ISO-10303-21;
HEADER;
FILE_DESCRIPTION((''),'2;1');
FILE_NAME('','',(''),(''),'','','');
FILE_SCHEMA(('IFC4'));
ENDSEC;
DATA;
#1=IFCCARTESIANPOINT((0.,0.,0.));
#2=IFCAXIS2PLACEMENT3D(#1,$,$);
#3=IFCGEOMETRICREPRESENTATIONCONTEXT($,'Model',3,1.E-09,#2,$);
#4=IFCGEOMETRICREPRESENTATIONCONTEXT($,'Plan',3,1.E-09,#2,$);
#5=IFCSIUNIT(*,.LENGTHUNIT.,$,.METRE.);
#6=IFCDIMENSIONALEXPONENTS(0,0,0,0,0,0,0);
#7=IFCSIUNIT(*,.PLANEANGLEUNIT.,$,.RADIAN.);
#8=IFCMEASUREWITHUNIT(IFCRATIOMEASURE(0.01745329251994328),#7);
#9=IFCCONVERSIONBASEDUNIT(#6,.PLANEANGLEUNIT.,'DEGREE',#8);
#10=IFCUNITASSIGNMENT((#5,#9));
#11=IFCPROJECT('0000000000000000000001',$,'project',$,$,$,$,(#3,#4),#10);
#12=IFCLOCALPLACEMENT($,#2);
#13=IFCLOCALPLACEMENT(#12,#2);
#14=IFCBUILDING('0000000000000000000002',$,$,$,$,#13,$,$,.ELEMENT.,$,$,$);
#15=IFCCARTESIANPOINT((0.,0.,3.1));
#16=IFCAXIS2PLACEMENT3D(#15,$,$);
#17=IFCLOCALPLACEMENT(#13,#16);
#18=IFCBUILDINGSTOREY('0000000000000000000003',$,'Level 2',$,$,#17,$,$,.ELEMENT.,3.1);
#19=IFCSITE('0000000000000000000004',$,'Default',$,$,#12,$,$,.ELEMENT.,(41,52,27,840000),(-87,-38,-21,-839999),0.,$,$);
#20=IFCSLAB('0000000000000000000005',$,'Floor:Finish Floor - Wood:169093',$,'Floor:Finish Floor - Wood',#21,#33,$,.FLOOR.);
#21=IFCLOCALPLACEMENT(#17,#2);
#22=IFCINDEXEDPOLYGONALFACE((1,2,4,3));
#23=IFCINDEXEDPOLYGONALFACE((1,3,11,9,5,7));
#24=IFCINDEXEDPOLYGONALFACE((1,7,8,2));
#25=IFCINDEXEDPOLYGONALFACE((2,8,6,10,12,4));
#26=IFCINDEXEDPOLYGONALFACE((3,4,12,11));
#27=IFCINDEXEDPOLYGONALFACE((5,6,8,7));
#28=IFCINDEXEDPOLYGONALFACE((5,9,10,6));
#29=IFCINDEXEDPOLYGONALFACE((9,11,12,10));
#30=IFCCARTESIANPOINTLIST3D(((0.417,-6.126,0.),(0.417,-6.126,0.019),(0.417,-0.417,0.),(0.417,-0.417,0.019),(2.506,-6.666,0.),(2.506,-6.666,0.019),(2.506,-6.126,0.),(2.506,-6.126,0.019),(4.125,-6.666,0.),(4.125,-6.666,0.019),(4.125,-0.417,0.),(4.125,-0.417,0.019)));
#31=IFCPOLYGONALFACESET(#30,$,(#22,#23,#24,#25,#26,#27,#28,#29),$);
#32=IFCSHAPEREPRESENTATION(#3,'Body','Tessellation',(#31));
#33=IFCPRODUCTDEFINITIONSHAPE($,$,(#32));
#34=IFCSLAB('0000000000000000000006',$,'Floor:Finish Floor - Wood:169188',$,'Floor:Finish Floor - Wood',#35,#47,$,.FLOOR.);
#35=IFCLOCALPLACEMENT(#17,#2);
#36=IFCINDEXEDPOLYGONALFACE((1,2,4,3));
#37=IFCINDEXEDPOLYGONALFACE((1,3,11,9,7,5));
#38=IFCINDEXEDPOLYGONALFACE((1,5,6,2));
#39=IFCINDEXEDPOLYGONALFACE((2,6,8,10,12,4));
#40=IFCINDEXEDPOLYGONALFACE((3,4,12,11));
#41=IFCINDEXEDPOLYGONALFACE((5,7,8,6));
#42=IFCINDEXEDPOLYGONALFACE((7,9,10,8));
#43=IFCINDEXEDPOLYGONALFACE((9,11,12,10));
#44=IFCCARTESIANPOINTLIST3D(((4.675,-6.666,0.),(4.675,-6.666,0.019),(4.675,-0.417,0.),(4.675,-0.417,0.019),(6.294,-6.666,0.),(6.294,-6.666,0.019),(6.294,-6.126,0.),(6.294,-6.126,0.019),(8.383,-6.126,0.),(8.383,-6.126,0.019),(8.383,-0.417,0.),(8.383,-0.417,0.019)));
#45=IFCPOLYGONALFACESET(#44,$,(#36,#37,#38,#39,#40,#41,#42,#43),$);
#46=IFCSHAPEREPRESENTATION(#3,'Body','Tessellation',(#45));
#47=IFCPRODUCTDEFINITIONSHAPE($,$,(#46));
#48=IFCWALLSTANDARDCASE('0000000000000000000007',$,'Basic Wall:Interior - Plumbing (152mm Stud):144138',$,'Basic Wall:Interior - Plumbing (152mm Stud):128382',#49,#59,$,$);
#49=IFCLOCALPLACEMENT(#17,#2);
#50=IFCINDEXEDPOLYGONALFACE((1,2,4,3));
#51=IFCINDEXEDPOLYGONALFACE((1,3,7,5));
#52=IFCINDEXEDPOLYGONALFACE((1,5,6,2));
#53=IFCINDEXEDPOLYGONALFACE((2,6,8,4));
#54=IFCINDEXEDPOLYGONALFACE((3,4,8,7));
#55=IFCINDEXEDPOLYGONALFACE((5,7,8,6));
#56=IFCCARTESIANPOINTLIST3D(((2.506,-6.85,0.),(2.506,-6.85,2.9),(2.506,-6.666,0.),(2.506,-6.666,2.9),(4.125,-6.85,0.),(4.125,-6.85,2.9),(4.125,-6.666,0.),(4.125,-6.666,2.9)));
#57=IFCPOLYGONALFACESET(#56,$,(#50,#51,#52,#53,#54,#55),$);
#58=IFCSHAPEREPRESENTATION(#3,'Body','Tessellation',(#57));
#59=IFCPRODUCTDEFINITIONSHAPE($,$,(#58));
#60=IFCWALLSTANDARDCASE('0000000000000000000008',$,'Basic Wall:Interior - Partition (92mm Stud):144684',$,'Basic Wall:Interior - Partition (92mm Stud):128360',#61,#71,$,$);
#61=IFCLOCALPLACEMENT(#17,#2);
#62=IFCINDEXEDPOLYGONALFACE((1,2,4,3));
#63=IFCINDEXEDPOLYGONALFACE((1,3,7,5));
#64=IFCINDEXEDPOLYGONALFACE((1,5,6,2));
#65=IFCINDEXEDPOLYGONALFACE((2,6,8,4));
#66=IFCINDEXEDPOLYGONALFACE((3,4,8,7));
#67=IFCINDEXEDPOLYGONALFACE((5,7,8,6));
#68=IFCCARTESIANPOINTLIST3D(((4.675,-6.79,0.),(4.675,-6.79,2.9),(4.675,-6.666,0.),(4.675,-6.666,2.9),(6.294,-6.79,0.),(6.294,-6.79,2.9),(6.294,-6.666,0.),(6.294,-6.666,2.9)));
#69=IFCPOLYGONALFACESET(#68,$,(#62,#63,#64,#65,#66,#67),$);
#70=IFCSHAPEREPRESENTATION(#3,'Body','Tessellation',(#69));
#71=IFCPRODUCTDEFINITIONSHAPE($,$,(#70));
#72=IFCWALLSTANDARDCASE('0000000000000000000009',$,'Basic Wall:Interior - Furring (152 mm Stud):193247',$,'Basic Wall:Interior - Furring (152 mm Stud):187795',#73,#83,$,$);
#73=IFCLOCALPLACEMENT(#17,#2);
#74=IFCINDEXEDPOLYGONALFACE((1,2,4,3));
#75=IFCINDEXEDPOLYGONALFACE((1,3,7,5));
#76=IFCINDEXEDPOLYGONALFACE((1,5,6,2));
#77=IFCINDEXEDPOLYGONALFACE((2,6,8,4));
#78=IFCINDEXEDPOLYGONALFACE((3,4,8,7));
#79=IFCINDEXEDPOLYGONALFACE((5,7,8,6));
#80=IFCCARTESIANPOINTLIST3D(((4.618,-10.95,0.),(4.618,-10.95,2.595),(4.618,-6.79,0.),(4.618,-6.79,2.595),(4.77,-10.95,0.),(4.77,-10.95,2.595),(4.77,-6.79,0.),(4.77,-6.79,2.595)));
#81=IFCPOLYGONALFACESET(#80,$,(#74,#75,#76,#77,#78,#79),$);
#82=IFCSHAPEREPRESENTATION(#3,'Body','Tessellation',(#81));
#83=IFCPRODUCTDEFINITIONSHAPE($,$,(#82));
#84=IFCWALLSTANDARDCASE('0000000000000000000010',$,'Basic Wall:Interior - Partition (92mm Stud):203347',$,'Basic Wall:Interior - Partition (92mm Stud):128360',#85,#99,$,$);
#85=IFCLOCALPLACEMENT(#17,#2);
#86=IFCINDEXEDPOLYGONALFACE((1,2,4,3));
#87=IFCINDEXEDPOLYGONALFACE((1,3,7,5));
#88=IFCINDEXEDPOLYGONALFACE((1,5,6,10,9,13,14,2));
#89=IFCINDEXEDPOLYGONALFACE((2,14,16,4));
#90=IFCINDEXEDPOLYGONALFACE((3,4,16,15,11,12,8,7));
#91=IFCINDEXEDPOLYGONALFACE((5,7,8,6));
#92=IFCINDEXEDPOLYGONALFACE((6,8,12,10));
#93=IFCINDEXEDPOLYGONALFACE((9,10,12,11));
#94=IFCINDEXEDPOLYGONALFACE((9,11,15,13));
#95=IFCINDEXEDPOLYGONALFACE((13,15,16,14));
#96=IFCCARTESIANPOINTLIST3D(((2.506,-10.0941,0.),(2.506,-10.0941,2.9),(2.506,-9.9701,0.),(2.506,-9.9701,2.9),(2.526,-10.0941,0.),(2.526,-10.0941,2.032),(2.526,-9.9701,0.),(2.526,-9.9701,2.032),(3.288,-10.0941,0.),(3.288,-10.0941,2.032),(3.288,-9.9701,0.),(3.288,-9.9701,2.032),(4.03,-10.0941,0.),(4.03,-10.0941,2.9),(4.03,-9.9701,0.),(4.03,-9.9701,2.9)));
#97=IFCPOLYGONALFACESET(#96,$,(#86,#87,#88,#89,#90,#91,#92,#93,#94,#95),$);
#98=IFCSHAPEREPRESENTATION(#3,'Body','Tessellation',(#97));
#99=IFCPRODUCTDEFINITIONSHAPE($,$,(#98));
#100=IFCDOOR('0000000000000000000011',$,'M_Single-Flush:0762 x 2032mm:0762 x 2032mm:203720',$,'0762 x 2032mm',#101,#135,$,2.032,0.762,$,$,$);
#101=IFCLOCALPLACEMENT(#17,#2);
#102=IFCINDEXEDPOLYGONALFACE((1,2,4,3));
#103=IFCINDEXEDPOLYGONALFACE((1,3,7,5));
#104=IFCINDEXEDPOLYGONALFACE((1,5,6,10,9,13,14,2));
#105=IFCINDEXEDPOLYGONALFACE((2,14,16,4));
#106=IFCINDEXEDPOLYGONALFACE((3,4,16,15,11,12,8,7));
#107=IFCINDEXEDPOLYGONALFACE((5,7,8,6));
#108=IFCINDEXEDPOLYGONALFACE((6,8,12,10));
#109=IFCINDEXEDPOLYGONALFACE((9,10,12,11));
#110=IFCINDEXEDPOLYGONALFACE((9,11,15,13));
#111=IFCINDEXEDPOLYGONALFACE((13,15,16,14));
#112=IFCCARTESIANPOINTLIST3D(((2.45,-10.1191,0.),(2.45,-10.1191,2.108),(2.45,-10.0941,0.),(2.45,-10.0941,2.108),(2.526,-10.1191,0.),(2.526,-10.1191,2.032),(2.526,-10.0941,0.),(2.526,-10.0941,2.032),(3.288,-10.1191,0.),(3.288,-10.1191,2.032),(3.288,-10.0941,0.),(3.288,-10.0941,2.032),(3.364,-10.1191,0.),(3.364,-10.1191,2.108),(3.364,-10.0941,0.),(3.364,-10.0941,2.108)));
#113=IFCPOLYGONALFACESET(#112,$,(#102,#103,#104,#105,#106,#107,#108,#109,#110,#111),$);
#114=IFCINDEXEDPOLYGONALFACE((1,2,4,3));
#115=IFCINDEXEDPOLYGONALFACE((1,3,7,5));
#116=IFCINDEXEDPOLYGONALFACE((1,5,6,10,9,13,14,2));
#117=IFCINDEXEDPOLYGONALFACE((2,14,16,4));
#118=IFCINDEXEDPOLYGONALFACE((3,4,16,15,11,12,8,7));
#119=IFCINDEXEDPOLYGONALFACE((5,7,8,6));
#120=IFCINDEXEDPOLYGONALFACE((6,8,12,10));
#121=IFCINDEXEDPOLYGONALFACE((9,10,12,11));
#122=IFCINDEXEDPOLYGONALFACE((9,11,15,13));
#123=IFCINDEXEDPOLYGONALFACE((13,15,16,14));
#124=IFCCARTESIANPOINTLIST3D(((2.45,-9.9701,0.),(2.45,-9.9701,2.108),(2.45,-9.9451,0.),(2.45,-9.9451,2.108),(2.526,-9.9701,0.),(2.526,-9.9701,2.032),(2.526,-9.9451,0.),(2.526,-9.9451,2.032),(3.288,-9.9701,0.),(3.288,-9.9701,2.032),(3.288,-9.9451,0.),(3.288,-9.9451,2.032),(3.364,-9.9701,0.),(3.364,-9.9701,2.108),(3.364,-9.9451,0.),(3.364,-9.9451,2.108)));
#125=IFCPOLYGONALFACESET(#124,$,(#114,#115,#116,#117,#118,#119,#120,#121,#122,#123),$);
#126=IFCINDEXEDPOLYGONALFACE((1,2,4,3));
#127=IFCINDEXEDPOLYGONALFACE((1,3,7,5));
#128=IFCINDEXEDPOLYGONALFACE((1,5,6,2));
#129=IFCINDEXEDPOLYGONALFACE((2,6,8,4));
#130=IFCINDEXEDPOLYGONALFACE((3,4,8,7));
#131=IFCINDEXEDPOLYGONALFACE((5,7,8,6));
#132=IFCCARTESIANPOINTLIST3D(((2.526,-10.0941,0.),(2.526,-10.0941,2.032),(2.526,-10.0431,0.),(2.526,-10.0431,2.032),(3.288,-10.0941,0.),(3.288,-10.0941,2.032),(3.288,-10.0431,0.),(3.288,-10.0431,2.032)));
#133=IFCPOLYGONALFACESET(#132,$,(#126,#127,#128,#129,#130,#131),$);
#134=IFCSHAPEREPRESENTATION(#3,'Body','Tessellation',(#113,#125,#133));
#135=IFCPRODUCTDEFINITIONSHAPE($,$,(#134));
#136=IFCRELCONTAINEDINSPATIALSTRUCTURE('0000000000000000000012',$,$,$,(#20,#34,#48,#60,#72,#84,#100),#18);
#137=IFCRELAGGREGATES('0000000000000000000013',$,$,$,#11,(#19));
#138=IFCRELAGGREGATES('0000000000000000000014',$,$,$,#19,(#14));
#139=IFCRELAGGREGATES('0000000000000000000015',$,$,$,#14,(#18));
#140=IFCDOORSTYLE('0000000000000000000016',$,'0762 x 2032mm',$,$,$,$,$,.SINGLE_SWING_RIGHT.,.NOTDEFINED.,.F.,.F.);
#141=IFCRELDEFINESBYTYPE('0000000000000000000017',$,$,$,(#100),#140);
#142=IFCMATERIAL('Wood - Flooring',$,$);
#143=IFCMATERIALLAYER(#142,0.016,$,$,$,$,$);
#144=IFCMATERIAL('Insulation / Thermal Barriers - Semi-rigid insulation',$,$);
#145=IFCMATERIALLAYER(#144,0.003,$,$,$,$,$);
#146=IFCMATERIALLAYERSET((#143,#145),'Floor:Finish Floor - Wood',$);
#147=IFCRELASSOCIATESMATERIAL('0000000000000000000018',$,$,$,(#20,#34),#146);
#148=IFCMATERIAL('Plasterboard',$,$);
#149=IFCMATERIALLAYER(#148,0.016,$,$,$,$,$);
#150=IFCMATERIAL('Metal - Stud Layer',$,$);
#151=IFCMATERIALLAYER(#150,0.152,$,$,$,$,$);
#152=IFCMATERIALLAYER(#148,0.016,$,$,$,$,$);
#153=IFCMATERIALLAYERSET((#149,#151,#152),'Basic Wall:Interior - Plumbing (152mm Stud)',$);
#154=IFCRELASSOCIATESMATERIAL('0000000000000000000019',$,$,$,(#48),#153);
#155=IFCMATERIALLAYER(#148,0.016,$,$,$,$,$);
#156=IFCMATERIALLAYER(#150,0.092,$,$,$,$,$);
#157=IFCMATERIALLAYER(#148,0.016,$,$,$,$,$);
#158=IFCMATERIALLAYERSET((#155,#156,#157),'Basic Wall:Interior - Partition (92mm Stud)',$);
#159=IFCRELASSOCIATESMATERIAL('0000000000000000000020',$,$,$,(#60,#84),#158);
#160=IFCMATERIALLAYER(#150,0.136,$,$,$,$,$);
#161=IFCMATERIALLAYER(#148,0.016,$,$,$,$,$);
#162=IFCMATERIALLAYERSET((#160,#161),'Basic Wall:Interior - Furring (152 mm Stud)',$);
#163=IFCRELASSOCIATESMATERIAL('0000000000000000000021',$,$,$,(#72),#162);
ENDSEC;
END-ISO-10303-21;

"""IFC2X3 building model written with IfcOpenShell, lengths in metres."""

from ifc_helpers import new_model, entity, si_unit, converted_unit, frame, frame_2d, origin, origin_2d_with_axis, place, context, project, spatial, polyline, rectangle, outline, extrude, source, transform, mapped, material, layer, layer_set, layer_usage, type_object, type_shapes, element, fill, save


model = new_model("IFC2X3")

# Units and contexts
model_context = context("Model", 3, precision=1e-09, world=origin())
plan_context = context("Plan", 3, precision=1e-09, world=origin())
ifc_project = project(units=[si_unit("LENGTHUNIT", "METRE"), converted_unit("PLANEANGLEUNIT", "DEGREE", entity("IfcRatioMeasure", 0.01745329251994328), si_unit("PLANEANGLEUNIT", "RADIAN"), dimensions=[0, 0, 0, 0, 0, 0, 0])], contexts=[model_context, plan_context])

# Site, building, storey
site_placement = place(None, origin())
site = spatial("IfcSite", under=ifc_project, at=site_placement, Name="Default", CompositionType="ELEMENT", RefLatitude=(41, 52, 27, 840000), RefLongitude=(-87, -38, -21, -839999), RefElevation=0.0)
building_placement = place(site_placement, origin())
building = spatial("IfcBuilding", under=site, at=building_placement, CompositionType="ELEMENT")
storey_placement = place(building_placement, frame((0.0, 0.0, 3.1)))
storey = spatial("IfcBuildingStorey", under=building, at=storey_placement, Name="Level 2", CompositionType="ELEMENT", Elevation=3.1)

# Slabs
ifc_material_1 = material(Name="Wood - Flooring")
ifc_layer_1 = layer(ifc_material_1, 0.016)
ifc_material_2 = material(Name="Insulation / Thermal Barriers - Semi-rigid insulation")
ifc_layer_2 = layer(ifc_material_2, 0.003)
ifc_layer_set_1 = layer_set([ifc_layer_1, ifc_layer_2], Name="Floor:Finish Floor - Wood")
ifc_layer_usage_1 = layer_usage(ifc_layer_set_1, "AXIS3", "POSITIVE", 0.0)
slab_1_placement = place(storey_placement, frame((0.417, -6.666, 0.0)))
element("IfcSlab", 1, at=slab_1_placement, inside=storey, material=ifc_layer_usage_1, Name="Floor:Finish Floor - Wood:169093", ObjectType="Floor:Finish Floor - Wood", PredefinedType="FLOOR", context=model_context, shape_type="SweptSolid", body=[
    extrude(outline(polyline([(1.854, 3.1245), (-1.854, 3.1245), (-1.854, -3.1245), (-0.235, -3.1245), (-0.235, -2.5845), (1.854, -2.5845), (1.854, 3.1245)])), frame((1.854, 3.1245, 0.019), z_axis=(0.0, 0.0, -1.0), x_axis=(-1.0, 0.0, 0.0)), (0.0, 0.0, 1.0), 0.019),
])
ifc_layer_usage_2 = layer_usage(ifc_layer_set_1, "AXIS3", "POSITIVE", 0.0)
slab_2_placement = place(storey_placement, frame((4.675, -6.666, 0.0)))
element("IfcSlab", 2, at=slab_2_placement, inside=storey, material=ifc_layer_usage_2, Name="Floor:Finish Floor - Wood:169188", ObjectType="Floor:Finish Floor - Wood", PredefinedType="FLOOR", context=model_context, shape_type="SweptSolid", body=[
    extrude(outline(polyline([(-1.854, 3.1245), (-1.854, -2.5845), (0.235, -2.5845), (0.235, -3.1245), (1.854, -3.1245), (1.854, 3.1245), (-1.854, 3.1245)])), frame((1.854, 3.1245, 0.019), z_axis=(0.0, 0.0, -1.0), x_axis=(-1.0, 0.0, 0.0)), (0.0, 0.0, 1.0), 0.019),
])

# Walls
ifc_material_3 = material(Name="Plasterboard")
ifc_layer_3 = layer(ifc_material_3, 0.016)
ifc_material_4 = material(Name="Metal - Stud Layer")
ifc_layer_4 = layer(ifc_material_4, 0.152)
ifc_layer_5 = layer(ifc_material_3, 0.016)
ifc_layer_set_2 = layer_set([ifc_layer_3, ifc_layer_4, ifc_layer_5], Name="Basic Wall:Interior - Plumbing (152mm Stud)")
ifc_layer_usage_3 = layer_usage(ifc_layer_set_2, "AXIS2", "NEGATIVE", 0.092)
wall_1_placement = place(storey_placement, frame((2.506, -6.758, 0.0)))
element("IfcWallStandardCase", 3, at=wall_1_placement, inside=storey, material=ifc_layer_usage_3, Name="Basic Wall:Interior - Plumbing (152mm Stud):144138", ObjectType="Basic Wall:Interior - Plumbing (152mm Stud):128382", context=model_context, shape_type="SweptSolid", body=[
    extrude(rectangle(XDim=1.619, YDim=0.184, at=frame_2d((0.8095, 0.0), x_axis=(-1.0, 0.0))), origin(), (0.0, 0.0, 1.0), 2.9),
])
ifc_layer_6 = layer(ifc_material_3, 0.016)
ifc_layer_7 = layer(ifc_material_4, 0.092)
ifc_layer_8 = layer(ifc_material_3, 0.016)
ifc_layer_set_3 = layer_set([ifc_layer_6, ifc_layer_7, ifc_layer_8], Name="Basic Wall:Interior - Partition (92mm Stud)")
ifc_layer_usage_4 = layer_usage(ifc_layer_set_3, "AXIS2", "NEGATIVE", 0.062)
wall_2_placement = place(storey_placement, frame((4.675, -6.728, 0.0)))
element("IfcWallStandardCase", 4, at=wall_2_placement, inside=storey, material=ifc_layer_usage_4, Name="Basic Wall:Interior - Partition (92mm Stud):144684", ObjectType="Basic Wall:Interior - Partition (92mm Stud):128360", context=model_context, shape_type="SweptSolid", body=[
    extrude(rectangle(XDim=1.619, YDim=0.124, at=frame_2d((0.8095, 0.0), x_axis=(-1.0, 0.0))), origin(), (0.0, 0.0, 1.0), 2.9),
])
ifc_layer_9 = layer(ifc_material_4, 0.136)
ifc_layer_10 = layer(ifc_material_3, 0.016)
ifc_layer_set_4 = layer_set([ifc_layer_9, ifc_layer_10], Name="Basic Wall:Interior - Furring (152 mm Stud)")
ifc_layer_usage_5 = layer_usage(ifc_layer_set_4, "AXIS2", "POSITIVE", -0.076)
wall_3_placement = place(storey_placement, frame((4.694, -6.79, 0.0), z_axis=(0.0, 0.0, 1.0), x_axis=(0.0, -1.0, 0.0)))
element("IfcWallStandardCase", 5, at=wall_3_placement, inside=storey, material=ifc_layer_usage_5, Name="Basic Wall:Interior - Furring (152 mm Stud):193247", ObjectType="Basic Wall:Interior - Furring (152 mm Stud):187795", context=model_context, shape_type="SweptSolid", body=[
    extrude(rectangle(XDim=4.16, YDim=0.152, at=frame_2d((2.08, 0.0), x_axis=(-1.0, 0.0))), origin(), (0.0, 0.0, 1.0), 2.595),
])

# Wall, opening, door
ifc_layer_usage_6 = layer_usage(ifc_layer_set_3, "AXIS2", "NEGATIVE", 0.062)
wall_4_placement = place(storey_placement, frame((4.03, -10.0321, 0.0), z_axis=(0.0, 0.0, 1.0), x_axis=(-1.0, 0.0, 0.0)))
wall_4 = element("IfcWallStandardCase", 6, at=wall_4_placement, inside=storey, material=ifc_layer_usage_6, Name="Basic Wall:Interior - Partition (92mm Stud):203347", ObjectType="Basic Wall:Interior - Partition (92mm Stud):128360", context=model_context, shape_type="SweptSolid", body=[
    extrude(rectangle(XDim=1.524, YDim=0.124, at=frame_2d((0.762, 0.0), x_axis=(-1.0, 0.0))), origin(), (0.0, 0.0, 1.0), 2.9),
])
opening_1_placement = place(wall_4_placement, frame((0.742, -0.062, 0.0)))
opening_1 = element("IfcOpeningElement", 7, at=opening_1_placement, cuts=wall_4, ObjectType="Opening", context=model_context, shape_type="SweptSolid", body=[
    extrude(rectangle(XDim=0.762, YDim=2.032, at=frame_2d((1.016, 0.381), x_axis=(0.0, 1.0))), frame((0.0, 0.0, 0.0), z_axis=(0.0, 1.0, 0.0), x_axis=(0.0, 0.0, 1.0)), (0.0, 0.0, 1.0), 0.124),
])
door_style = type_object("IfcDoorStyle", Name="0762 x 2032mm", ConstructionType="NOTDEFINED", OperationType="SINGLE_SWING_RIGHT", ParameterTakesPrecedence=False, Sizeable=False)
shared_shape = source(origin(), model_context, "Body", "SweptSolid", [
    extrude(outline(polyline([(-0.457, -1.073), (0.457, -1.073), (0.457, 1.035), (0.381, 1.035), (0.381, -0.997), (-0.381, -0.997), (-0.381, 1.035), (-0.457, 1.035), (-0.457, -1.073)])), frame((0.381, 0.124, 1.035), z_axis=(0.0, 1.0, 0.0), x_axis=(1.0, 0.0, 0.0)), (0.0, 0.0, 1.0), 0.025),
    extrude(outline(polyline([(-1.073, -0.457), (1.035, -0.457), (1.035, -0.381), (-0.997, -0.381), (-0.997, 0.381), (1.035, 0.381), (1.035, 0.457), (-1.073, 0.457), (-1.073, -0.457)])), frame((0.381, -0.025, 1.035), z_axis=(0.0, 1.0, 0.0), x_axis=(0.0, 0.0, -1.0)), (0.0, 0.0, 1.0), 0.025),
    extrude(rectangle(XDim=0.051, YDim=0.762, at=origin_2d_with_axis()), frame((0.381, 0.0985, 0.0), z_axis=(0.0, 0.0, 1.0), x_axis=(0.0, 1.0, 0.0)), (0.0, 0.0, 1.0), 2.032),
])
type_shapes(door_style, [shared_shape])
door_1_placement = place(opening_1_placement, origin())
door_1 = element("IfcDoor", 8, at=door_1_placement, inside=storey, type_object=door_style, Name="M_Single-Flush:0762 x 2032mm:0762 x 2032mm:203720", ObjectType="0762 x 2032mm", OverallHeight=2.032, OverallWidth=0.762, context=model_context, shape_type="MappedRepresentation", body=[
    mapped(shared_shape, transform((0.0, 0.0, 0.0), scale=1.0)),
])
fill(opening_1, door_1)

save(model, "model.ifc")
